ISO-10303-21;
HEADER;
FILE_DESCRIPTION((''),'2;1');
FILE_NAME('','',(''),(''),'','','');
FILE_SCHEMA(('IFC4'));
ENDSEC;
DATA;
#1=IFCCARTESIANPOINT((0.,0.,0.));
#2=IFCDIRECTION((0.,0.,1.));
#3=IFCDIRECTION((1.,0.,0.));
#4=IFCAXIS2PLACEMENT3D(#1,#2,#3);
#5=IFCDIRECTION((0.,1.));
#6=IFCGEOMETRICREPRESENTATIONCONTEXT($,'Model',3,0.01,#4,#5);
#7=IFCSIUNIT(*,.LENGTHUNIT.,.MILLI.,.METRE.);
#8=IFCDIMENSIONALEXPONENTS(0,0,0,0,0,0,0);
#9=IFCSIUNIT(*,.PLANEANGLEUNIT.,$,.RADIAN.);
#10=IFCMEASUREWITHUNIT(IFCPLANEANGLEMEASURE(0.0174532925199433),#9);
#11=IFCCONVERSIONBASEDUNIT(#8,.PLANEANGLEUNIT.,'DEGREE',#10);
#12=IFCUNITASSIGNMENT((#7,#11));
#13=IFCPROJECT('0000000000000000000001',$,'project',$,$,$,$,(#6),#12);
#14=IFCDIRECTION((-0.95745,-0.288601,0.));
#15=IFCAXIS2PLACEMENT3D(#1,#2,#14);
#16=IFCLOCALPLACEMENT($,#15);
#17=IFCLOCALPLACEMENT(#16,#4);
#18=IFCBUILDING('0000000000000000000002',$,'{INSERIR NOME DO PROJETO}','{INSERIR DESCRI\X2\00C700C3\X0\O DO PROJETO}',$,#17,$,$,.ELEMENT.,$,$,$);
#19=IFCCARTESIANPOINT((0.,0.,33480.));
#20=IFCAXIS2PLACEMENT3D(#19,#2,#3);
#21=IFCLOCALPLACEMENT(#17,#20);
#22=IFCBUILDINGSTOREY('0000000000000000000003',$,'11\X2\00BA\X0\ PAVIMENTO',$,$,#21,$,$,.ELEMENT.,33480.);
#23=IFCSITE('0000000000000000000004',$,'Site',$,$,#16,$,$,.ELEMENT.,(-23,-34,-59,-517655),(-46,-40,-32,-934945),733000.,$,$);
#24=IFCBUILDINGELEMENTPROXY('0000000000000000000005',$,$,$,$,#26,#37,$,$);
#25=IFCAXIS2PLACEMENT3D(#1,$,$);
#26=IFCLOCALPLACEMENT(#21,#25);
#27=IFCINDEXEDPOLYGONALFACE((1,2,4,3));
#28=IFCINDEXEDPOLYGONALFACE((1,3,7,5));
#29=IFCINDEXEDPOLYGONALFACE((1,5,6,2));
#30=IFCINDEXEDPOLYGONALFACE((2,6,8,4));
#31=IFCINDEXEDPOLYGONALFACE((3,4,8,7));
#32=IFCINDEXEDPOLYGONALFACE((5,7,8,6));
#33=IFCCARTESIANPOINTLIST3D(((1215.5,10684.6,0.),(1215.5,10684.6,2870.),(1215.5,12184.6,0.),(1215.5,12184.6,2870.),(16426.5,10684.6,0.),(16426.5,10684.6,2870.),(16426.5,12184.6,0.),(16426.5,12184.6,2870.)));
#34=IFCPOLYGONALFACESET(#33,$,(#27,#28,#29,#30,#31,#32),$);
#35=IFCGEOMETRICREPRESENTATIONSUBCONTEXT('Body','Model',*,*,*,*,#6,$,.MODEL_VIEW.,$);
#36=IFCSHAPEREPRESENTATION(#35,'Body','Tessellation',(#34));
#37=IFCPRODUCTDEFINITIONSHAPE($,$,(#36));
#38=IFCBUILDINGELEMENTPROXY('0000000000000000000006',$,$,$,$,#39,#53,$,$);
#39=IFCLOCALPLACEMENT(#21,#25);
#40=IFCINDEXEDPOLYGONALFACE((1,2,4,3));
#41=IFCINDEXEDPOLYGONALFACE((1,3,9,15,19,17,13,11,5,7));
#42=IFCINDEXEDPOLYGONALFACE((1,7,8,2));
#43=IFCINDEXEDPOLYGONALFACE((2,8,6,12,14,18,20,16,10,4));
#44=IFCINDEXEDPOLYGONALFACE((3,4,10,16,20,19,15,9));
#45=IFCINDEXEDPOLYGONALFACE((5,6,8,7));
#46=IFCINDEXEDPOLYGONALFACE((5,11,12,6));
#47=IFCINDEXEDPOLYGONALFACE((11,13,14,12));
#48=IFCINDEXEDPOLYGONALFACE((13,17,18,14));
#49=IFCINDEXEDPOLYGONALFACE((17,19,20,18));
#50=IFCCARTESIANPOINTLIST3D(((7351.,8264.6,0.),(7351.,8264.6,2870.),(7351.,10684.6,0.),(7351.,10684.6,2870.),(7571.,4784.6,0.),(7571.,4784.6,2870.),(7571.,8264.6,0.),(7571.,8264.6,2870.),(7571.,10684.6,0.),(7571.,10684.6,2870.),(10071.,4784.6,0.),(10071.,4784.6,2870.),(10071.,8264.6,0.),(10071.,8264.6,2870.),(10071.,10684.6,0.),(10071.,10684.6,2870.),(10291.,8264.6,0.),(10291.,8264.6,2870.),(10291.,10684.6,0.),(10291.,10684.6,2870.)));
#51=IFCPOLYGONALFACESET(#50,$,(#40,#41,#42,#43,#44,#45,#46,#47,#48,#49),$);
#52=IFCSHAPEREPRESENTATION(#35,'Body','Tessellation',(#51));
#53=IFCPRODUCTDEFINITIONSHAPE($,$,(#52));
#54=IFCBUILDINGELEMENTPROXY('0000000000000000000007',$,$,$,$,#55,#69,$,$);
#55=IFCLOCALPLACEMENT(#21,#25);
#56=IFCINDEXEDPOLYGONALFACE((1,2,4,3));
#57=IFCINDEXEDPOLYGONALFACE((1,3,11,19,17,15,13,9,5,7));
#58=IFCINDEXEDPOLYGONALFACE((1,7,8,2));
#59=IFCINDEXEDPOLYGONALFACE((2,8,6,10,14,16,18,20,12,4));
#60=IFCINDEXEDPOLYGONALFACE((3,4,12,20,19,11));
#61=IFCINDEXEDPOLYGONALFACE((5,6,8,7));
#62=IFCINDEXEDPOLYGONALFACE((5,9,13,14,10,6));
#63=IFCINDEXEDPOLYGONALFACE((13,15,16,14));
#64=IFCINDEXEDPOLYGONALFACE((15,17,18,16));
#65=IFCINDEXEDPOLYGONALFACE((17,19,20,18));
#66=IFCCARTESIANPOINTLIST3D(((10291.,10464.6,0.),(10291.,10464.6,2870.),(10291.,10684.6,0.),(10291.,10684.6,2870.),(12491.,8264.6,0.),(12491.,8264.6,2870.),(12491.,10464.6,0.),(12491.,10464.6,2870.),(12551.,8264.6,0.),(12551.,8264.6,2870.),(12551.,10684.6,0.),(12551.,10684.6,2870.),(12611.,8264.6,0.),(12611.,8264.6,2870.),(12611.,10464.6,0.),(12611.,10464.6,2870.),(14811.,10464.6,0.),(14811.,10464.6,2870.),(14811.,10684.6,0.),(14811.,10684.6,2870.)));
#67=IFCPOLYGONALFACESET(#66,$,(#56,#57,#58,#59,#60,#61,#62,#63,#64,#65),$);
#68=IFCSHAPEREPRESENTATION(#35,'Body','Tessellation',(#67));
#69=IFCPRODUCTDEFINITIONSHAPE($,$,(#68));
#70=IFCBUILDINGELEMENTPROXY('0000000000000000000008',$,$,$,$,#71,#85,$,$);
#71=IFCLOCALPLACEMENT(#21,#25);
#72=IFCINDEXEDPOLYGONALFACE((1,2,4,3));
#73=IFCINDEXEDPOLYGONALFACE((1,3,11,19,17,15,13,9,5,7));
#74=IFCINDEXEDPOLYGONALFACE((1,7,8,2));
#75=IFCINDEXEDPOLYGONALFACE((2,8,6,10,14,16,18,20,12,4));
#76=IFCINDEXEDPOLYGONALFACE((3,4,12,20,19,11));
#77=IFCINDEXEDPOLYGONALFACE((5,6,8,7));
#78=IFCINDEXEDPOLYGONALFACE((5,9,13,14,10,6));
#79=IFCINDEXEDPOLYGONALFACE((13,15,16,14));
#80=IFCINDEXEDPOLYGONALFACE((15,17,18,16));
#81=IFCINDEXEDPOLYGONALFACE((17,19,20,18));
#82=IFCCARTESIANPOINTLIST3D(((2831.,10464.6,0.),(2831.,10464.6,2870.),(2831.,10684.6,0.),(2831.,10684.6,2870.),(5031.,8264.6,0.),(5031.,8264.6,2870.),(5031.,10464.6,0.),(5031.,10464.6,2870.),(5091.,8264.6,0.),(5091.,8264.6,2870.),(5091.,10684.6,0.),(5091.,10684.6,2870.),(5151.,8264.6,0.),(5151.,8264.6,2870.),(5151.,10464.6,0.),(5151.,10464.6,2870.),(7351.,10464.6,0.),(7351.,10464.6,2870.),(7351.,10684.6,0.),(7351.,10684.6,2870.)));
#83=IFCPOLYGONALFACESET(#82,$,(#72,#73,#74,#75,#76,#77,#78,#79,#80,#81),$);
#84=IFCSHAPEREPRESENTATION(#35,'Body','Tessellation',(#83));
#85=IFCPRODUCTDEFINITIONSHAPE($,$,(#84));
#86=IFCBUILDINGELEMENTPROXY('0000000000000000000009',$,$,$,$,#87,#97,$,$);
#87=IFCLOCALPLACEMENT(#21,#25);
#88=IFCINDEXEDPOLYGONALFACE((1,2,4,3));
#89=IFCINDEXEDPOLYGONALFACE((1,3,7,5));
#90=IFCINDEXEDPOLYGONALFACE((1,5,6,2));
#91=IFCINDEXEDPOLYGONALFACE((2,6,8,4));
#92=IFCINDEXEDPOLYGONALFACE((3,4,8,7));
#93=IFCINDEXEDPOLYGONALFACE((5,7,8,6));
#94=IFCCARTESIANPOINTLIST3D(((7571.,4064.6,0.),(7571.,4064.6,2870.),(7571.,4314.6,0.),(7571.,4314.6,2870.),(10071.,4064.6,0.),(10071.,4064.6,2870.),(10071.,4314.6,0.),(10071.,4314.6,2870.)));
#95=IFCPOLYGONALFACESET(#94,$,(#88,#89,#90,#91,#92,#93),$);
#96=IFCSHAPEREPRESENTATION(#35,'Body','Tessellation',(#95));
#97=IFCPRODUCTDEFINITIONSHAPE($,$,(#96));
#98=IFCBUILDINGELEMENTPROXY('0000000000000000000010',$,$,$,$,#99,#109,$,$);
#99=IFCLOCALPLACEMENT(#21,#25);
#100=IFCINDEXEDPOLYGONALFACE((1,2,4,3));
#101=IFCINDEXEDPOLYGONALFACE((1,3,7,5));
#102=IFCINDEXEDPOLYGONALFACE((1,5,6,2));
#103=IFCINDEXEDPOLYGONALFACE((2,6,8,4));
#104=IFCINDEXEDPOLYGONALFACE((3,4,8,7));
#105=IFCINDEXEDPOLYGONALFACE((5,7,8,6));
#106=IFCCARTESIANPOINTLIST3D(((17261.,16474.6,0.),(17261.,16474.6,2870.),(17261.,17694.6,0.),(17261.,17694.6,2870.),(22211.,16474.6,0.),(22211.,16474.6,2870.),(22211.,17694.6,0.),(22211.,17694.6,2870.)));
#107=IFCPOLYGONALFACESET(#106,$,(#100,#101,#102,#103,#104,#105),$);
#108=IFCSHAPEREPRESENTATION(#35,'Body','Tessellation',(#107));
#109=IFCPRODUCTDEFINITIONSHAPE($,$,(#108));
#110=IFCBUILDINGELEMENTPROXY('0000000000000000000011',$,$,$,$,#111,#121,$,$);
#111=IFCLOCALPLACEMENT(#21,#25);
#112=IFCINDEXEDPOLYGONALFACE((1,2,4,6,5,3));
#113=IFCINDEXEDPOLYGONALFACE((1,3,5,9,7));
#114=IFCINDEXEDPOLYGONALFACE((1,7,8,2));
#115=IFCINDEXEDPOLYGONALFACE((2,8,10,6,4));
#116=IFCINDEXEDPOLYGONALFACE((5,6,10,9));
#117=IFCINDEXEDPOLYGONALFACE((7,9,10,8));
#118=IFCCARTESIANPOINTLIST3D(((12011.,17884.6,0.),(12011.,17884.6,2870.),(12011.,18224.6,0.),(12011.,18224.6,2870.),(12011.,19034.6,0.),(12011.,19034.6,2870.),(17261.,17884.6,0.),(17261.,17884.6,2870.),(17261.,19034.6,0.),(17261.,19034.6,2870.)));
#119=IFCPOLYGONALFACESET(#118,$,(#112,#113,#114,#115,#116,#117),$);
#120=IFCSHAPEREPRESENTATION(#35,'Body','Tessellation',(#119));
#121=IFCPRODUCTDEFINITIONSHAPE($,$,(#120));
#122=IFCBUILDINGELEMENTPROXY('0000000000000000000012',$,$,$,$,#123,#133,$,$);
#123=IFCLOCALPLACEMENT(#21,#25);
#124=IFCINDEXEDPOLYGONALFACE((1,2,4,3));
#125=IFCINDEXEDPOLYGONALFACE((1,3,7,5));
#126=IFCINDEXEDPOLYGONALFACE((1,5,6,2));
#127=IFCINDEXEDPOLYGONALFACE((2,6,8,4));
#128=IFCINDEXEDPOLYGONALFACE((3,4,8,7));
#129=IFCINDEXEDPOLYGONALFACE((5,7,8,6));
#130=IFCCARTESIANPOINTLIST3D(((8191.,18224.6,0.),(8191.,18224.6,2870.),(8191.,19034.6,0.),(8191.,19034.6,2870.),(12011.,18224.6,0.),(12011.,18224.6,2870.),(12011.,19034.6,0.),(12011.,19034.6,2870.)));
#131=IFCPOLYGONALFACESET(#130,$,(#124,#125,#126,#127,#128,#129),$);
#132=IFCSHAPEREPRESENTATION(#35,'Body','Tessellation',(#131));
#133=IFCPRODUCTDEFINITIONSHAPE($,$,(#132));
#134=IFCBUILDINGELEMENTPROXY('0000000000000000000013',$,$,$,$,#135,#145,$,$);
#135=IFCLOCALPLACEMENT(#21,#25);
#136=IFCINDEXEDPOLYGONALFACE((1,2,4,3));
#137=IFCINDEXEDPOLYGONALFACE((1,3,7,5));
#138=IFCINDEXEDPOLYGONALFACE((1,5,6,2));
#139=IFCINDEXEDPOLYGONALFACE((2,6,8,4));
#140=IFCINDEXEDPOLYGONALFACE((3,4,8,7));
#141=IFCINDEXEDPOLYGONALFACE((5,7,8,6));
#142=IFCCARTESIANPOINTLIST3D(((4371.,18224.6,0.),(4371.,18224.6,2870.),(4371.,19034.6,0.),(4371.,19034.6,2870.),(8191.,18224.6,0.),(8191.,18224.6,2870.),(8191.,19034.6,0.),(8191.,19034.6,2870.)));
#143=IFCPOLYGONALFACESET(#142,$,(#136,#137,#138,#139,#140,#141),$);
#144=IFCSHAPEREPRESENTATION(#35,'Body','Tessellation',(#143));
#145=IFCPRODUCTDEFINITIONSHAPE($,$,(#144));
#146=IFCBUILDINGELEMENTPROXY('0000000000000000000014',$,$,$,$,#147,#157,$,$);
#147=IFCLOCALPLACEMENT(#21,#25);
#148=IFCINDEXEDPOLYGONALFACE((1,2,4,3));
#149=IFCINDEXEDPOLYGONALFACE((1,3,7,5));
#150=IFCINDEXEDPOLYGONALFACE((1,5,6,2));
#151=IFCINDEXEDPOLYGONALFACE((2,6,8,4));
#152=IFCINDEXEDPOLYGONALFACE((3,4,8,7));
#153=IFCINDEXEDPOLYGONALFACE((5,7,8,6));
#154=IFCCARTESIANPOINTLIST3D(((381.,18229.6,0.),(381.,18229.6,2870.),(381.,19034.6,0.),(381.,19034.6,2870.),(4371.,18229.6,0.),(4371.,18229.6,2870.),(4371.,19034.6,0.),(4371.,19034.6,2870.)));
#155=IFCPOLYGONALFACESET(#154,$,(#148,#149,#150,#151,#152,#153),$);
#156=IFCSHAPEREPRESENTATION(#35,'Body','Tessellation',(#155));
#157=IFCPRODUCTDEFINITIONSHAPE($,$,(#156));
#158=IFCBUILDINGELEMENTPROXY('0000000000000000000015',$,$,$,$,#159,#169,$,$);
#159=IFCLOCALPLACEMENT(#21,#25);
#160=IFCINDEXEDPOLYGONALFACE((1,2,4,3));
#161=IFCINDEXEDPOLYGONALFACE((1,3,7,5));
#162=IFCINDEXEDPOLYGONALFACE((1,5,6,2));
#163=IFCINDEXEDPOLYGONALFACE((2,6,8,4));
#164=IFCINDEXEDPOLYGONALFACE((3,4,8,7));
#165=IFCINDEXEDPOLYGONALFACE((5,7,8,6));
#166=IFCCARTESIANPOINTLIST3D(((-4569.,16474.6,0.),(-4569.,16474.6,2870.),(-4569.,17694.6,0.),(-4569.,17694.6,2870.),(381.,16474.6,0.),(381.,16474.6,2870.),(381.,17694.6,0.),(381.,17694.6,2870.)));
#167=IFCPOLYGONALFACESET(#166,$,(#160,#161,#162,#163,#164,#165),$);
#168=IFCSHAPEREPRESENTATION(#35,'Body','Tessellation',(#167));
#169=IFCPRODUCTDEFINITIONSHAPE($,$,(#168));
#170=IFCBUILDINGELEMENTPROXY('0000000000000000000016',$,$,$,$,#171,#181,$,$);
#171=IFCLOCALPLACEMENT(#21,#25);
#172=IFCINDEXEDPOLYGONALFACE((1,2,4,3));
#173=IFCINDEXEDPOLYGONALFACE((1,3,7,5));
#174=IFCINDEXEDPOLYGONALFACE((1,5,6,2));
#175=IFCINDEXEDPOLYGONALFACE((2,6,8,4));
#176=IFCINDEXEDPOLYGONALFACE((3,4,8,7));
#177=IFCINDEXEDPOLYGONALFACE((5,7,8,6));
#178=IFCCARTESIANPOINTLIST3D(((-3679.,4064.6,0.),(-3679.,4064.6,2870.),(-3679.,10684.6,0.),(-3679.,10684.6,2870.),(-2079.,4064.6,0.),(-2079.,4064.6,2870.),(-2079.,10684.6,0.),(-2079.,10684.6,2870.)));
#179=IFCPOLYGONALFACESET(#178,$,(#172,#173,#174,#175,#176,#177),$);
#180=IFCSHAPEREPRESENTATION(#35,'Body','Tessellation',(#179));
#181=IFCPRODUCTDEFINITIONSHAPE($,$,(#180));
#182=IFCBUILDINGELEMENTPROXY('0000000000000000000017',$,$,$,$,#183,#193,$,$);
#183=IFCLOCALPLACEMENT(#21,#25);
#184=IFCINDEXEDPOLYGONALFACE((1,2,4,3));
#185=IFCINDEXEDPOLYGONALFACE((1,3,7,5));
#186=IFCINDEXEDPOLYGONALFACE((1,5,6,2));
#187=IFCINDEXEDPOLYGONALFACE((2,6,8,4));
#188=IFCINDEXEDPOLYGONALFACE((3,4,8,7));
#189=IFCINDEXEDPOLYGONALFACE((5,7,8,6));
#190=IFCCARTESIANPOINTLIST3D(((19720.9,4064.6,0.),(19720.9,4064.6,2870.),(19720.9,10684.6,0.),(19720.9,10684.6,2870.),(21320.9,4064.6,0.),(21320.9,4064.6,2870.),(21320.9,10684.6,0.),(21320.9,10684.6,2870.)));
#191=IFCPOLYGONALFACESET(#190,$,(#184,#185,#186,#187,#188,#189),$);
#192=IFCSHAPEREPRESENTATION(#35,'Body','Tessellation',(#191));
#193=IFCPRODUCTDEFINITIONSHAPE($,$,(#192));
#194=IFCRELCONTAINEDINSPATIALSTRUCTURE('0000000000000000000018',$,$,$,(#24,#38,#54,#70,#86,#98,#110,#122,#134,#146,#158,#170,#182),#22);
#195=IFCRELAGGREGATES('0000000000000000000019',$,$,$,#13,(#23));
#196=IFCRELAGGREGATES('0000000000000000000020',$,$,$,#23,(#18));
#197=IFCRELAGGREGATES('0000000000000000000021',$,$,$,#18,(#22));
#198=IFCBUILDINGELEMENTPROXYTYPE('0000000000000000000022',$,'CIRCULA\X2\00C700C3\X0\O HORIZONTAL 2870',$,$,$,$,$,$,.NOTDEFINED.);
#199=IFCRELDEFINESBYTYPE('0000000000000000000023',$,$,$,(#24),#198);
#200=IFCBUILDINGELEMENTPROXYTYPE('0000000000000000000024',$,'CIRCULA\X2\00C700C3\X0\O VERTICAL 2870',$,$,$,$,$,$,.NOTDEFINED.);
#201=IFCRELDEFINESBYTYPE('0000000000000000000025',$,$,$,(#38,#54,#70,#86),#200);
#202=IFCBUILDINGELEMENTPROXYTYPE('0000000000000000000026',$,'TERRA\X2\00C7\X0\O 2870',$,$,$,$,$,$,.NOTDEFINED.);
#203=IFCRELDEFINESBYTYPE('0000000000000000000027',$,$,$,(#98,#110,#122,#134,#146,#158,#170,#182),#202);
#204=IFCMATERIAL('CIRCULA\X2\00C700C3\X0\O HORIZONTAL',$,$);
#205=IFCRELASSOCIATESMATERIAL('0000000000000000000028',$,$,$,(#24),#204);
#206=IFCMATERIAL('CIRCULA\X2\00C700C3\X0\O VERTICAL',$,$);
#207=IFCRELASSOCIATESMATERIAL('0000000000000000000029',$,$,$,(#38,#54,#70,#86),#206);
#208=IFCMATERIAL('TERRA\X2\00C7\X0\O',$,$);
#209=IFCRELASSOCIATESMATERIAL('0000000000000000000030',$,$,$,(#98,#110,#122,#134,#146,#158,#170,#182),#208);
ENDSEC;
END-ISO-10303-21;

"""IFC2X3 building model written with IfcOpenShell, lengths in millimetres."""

from ifc_helpers import new_model, entity, si_unit, converted_unit, direction, frame, origin_with_axes, place, context, subcontext, project, spatial, polyline, outline, extrude, material, type_object, element, save


model = new_model("IFC2X3")

# Units and contexts
model_context = context("Model", 3, precision=0.01, world=origin_with_axes(), true_north=direction((0.0, 1.0)))
body_context = subcontext(model_context, "Body", "Model", "MODEL_VIEW")
ifc_project = project(units=[si_unit("LENGTHUNIT", "METRE", prefix="MILLI"), converted_unit("PLANEANGLEUNIT", "DEGREE", entity("IfcPlaneAngleMeasure", 0.0174532925199433), si_unit("PLANEANGLEUNIT", "RADIAN"), dimensions=[0, 0, 0, 0, 0, 0, 0])], contexts=[model_context])

# Site, building, storey
site_placement = place(None, frame((0.0, 0.0, 0.0), z_axis=(0.0, 0.0, 1.0), x_axis=(-0.95745, -0.288601, 0.0)))
site = spatial("IfcSite", under=ifc_project, at=site_placement, Name="Site", CompositionType="ELEMENT", RefLatitude=(-23, -34, -59, -517655), RefLongitude=(-46, -40, -32, -934945), RefElevation=733000.0)
building_placement = place(site_placement, origin_with_axes())
building = spatial("IfcBuilding", under=site, at=building_placement, Name="{INSERIR NOME DO PROJETO}", Description="{INSERIR DESCRIÇÃO DO PROJETO}", CompositionType="ELEMENT")
storey_placement = place(building_placement, frame((0.0, 0.0, 33480.0), z_axis=(0.0, 0.0, 1.0), x_axis=(1.0, 0.0, 0.0)))
storey = spatial("IfcBuildingStorey", under=building, at=storey_placement, Name="11º PAVIMENTO", CompositionType="ELEMENT", Elevation=33480.0)

# Building element proxies
ifc_material_1 = material(Name="CIRCULAÇÃO HORIZONTAL")
building_element_proxy_type_1 = type_object("IfcBuildingElementProxyType", Name="CIRCULAÇÃO HORIZONTAL 2870", PredefinedType="NOTDEFINED")
proxy_1_placement = place(storey_placement, frame((1215.5, 10684.6, 0.0), z_axis=(0.0, 0.0, 1.0), x_axis=(1.0, 0.0, 0.0)))
element("IfcBuildingElementProxy", 1, at=proxy_1_placement, inside=storey, type_object=building_element_proxy_type_1, material=ifc_material_1, context=body_context, shape_type="SweptSolid", body=[
    extrude(outline(polyline([(0.0, 0.0), (15211.0, 0.0), (15211.0, 1500.0), (0.0, 1500.0), (0.0, 0.0)])), origin_with_axes(), (0.0, 0.0, 1.0), 2870.0),
])
ifc_material_2 = material(Name="CIRCULAÇÃO VERTICAL")
building_element_proxy_type_2 = type_object("IfcBuildingElementProxyType", Name="CIRCULAÇÃO VERTICAL 2870", PredefinedType="NOTDEFINED")
proxy_2_placement = place(storey_placement, frame((7351.0, 10684.6, 0.0), z_axis=(0.0, 0.0, 1.0), x_axis=(1.0, 0.0, 0.0)))
element("IfcBuildingElementProxy", 2, at=proxy_2_placement, inside=storey, type_object=building_element_proxy_type_2, material=ifc_material_2, context=body_context, shape_type="SweptSolid", body=[
    extrude(outline(polyline([(0.0, 0.0), (0.0, -2420.0), (220.0, -2420.0), (220.0, -5900.0), (2720.0, -5900.0), (2720.0, -2420.0), (2940.0, -2420.0), (2940.0, 0.0), (2720.0, 0.0), (220.0, 0.0), (0.0, 0.0)])), origin_with_axes(), (0.0, 0.0, 1.0), 2870.0),
])
proxy_3_placement = place(storey_placement, frame((10291.0, 10684.6, 0.0), z_axis=(0.0, 0.0, 1.0), x_axis=(1.0, 0.0, 0.0)))
element("IfcBuildingElementProxy", 3, at=proxy_3_placement, inside=storey, type_object=building_element_proxy_type_2, material=ifc_material_2, context=body_context, shape_type="SweptSolid", body=[
    extrude(outline(polyline([(0.0, 0.0), (0.0, -220.0), (2200.0, -220.0), (2200.0, -2420.0), (2260.0, -2420.0), (2320.0, -2420.0), (2320.0, -220.0), (4520.0, -220.0), (4520.0, 0.0), (2260.0, 0.0), (0.0, 0.0)])), origin_with_axes(), (0.0, 0.0, 1.0), 2870.0),
])
proxy_4_placement = place(storey_placement, frame((5091.0, 10684.6, 0.0), z_axis=(0.0, 0.0, 1.0), x_axis=(1.0, 0.0, 0.0)))
element("IfcBuildingElementProxy", 4, at=proxy_4_placement, inside=storey, type_object=building_element_proxy_type_2, material=ifc_material_2, context=body_context, shape_type="SweptSolid", body=[
    extrude(outline(polyline([(0.0, 0.0), (-2260.0, 0.0), (-2260.0, -220.0), (-60.0, -220.0), (-60.0, -2420.0), (0.0, -2420.0), (60.0, -2420.0), (60.0, -220.0), (2260.0, -220.0), (2260.0, 0.0), (0.0, 0.0)])), origin_with_axes(), (0.0, 0.0, 1.0), 2870.0),
])
proxy_5_placement = place(storey_placement, frame((7571.0, 4064.6, 0.0), z_axis=(0.0, 0.0, 1.0), x_axis=(1.0, 0.0, 0.0)))
element("IfcBuildingElementProxy", 5, at=proxy_5_placement, inside=storey, type_object=building_element_proxy_type_2, material=ifc_material_2, context=body_context, shape_type="SweptSolid", body=[
    extrude(outline(polyline([(0.0, 0.0), (2500.0, 0.0), (2500.0, 250.0), (0.0, 250.0), (0.0, 0.0)])), origin_with_axes(), (0.0, 0.0, 1.0), 2870.0),
])
ifc_material_3 = material(Name="TERRAÇO")
building_element_proxy_type_3 = type_object("IfcBuildingElementProxyType", Name="TERRAÇO 2870", PredefinedType="NOTDEFINED")
proxy_6_placement = place(storey_placement, frame((17261.0, 16474.6, 0.0), z_axis=(0.0, 0.0, 1.0), x_axis=(1.0, 0.0, 0.0)))
element("IfcBuildingElementProxy", 6, at=proxy_6_placement, inside=storey, type_object=building_element_proxy_type_3, material=ifc_material_3, context=body_context, shape_type="SweptSolid", body=[
    extrude(outline(polyline([(0.0, 0.0), (4950.0, 0.0), (4950.0, 1220.0), (0.0, 1220.0), (0.0, 0.0)])), origin_with_axes(), (0.0, 0.0, 1.0), 2870.0),
])
proxy_7_placement = place(storey_placement, frame((12011.0, 19034.6, 0.0), z_axis=(0.0, 0.0, 1.0), x_axis=(1.0, 0.0, 0.0)))
element("IfcBuildingElementProxy", 7, at=proxy_7_placement, inside=storey, type_object=building_element_proxy_type_3, material=ifc_material_3, context=body_context, shape_type="SweptSolid", body=[
    extrude(outline(polyline([(0.0, 0.0), (0.0, -810.0), (0.0, -1150.0), (5250.0, -1150.0), (5250.0, 0.0), (0.0, 0.0)])), origin_with_axes(), (0.0, 0.0, 1.0), 2870.0),
])
for number, where, z_axis, x_axis in (
    (8, (8191.0, 18224.6, 0.0), (0.0, 0.0, 1.0), (1.0, 0.0, 0.0)),
    (9, (4371.0, 18224.6, 0.0), (0.0, 0.0, 1.0), (1.0, 0.0, 0.0)),
):
    element("IfcBuildingElementProxy", number, at=place(storey_placement, frame(where, z_axis=z_axis, x_axis=x_axis)), inside=storey, type_object=building_element_proxy_type_3, material=ifc_material_3, context=body_context, shape_type="SweptSolid", body=[
        extrude(outline(polyline([(0.0, 0.0), (3820.0, 0.0), (3820.0, 810.0), (0.0, 810.0), (0.0, 0.0)])), origin_with_axes(), (0.0, 0.0, 1.0), 2870.0),
    ])
proxy_8_placement = place(storey_placement, frame((381.0, 19034.6, 0.0), z_axis=(0.0, 0.0, 1.0), x_axis=(1.0, 0.0, 0.0)))
element("IfcBuildingElementProxy", 10, at=proxy_8_placement, inside=storey, type_object=building_element_proxy_type_3, material=ifc_material_3, context=body_context, shape_type="SweptSolid", body=[
    extrude(outline(polyline([(0.0, 0.0), (0.0, -805.0), (3990.0, -805.0), (3990.0, 0.0), (0.0, 0.0)])), origin_with_axes(), (0.0, 0.0, 1.0), 2870.0),
])
proxy_9_placement = place(storey_placement, frame((381.0, 17694.6, 0.0), z_axis=(0.0, 0.0, 1.0), x_axis=(1.0, 0.0, 0.0)))
element("IfcBuildingElementProxy", 11, at=proxy_9_placement, inside=storey, type_object=building_element_proxy_type_3, material=ifc_material_3, context=body_context, shape_type="SweptSolid", body=[
    extrude(outline(polyline([(0.0, 0.0), (-4950.0, 0.0), (-4950.0, -1220.0), (0.0, -1220.0), (0.0, 0.0)])), origin_with_axes(), (0.0, 0.0, 1.0), 2870.0),
])
proxy_10_placement = place(storey_placement, frame((-3679.0, 4064.6, 0.0), z_axis=(0.0, 0.0, 1.0), x_axis=(1.0, 0.0, 0.0)))
element("IfcBuildingElementProxy", 12, at=proxy_10_placement, inside=storey, type_object=building_element_proxy_type_3, material=ifc_material_3, context=body_context, shape_type="SweptSolid", body=[
    extrude(outline(polyline([(0.0, 0.0), (1600.0, 0.0), (1600.0, 6620.0), (0.0, 6620.0), (0.0, 0.0)])), origin_with_axes(), (0.0, 0.0, 1.0), 2870.0),
])
proxy_11_placement = place(storey_placement, frame((21320.9, 4064.6, 0.0), z_axis=(0.0, 0.0, 1.0), x_axis=(1.0, 0.0, 0.0)))
element("IfcBuildingElementProxy", 13, at=proxy_11_placement, inside=storey, type_object=building_element_proxy_type_3, material=ifc_material_3, context=body_context, shape_type="SweptSolid", body=[
    extrude(outline(polyline([(0.0, 0.0), (0.0, 6620.0), (-1600.0, 6620.0), (-1600.0, 0.0), (0.0, 0.0)])), origin_with_axes(), (0.0, 0.0, 1.0), 2870.0),
])

save(model, "model.ifc")
